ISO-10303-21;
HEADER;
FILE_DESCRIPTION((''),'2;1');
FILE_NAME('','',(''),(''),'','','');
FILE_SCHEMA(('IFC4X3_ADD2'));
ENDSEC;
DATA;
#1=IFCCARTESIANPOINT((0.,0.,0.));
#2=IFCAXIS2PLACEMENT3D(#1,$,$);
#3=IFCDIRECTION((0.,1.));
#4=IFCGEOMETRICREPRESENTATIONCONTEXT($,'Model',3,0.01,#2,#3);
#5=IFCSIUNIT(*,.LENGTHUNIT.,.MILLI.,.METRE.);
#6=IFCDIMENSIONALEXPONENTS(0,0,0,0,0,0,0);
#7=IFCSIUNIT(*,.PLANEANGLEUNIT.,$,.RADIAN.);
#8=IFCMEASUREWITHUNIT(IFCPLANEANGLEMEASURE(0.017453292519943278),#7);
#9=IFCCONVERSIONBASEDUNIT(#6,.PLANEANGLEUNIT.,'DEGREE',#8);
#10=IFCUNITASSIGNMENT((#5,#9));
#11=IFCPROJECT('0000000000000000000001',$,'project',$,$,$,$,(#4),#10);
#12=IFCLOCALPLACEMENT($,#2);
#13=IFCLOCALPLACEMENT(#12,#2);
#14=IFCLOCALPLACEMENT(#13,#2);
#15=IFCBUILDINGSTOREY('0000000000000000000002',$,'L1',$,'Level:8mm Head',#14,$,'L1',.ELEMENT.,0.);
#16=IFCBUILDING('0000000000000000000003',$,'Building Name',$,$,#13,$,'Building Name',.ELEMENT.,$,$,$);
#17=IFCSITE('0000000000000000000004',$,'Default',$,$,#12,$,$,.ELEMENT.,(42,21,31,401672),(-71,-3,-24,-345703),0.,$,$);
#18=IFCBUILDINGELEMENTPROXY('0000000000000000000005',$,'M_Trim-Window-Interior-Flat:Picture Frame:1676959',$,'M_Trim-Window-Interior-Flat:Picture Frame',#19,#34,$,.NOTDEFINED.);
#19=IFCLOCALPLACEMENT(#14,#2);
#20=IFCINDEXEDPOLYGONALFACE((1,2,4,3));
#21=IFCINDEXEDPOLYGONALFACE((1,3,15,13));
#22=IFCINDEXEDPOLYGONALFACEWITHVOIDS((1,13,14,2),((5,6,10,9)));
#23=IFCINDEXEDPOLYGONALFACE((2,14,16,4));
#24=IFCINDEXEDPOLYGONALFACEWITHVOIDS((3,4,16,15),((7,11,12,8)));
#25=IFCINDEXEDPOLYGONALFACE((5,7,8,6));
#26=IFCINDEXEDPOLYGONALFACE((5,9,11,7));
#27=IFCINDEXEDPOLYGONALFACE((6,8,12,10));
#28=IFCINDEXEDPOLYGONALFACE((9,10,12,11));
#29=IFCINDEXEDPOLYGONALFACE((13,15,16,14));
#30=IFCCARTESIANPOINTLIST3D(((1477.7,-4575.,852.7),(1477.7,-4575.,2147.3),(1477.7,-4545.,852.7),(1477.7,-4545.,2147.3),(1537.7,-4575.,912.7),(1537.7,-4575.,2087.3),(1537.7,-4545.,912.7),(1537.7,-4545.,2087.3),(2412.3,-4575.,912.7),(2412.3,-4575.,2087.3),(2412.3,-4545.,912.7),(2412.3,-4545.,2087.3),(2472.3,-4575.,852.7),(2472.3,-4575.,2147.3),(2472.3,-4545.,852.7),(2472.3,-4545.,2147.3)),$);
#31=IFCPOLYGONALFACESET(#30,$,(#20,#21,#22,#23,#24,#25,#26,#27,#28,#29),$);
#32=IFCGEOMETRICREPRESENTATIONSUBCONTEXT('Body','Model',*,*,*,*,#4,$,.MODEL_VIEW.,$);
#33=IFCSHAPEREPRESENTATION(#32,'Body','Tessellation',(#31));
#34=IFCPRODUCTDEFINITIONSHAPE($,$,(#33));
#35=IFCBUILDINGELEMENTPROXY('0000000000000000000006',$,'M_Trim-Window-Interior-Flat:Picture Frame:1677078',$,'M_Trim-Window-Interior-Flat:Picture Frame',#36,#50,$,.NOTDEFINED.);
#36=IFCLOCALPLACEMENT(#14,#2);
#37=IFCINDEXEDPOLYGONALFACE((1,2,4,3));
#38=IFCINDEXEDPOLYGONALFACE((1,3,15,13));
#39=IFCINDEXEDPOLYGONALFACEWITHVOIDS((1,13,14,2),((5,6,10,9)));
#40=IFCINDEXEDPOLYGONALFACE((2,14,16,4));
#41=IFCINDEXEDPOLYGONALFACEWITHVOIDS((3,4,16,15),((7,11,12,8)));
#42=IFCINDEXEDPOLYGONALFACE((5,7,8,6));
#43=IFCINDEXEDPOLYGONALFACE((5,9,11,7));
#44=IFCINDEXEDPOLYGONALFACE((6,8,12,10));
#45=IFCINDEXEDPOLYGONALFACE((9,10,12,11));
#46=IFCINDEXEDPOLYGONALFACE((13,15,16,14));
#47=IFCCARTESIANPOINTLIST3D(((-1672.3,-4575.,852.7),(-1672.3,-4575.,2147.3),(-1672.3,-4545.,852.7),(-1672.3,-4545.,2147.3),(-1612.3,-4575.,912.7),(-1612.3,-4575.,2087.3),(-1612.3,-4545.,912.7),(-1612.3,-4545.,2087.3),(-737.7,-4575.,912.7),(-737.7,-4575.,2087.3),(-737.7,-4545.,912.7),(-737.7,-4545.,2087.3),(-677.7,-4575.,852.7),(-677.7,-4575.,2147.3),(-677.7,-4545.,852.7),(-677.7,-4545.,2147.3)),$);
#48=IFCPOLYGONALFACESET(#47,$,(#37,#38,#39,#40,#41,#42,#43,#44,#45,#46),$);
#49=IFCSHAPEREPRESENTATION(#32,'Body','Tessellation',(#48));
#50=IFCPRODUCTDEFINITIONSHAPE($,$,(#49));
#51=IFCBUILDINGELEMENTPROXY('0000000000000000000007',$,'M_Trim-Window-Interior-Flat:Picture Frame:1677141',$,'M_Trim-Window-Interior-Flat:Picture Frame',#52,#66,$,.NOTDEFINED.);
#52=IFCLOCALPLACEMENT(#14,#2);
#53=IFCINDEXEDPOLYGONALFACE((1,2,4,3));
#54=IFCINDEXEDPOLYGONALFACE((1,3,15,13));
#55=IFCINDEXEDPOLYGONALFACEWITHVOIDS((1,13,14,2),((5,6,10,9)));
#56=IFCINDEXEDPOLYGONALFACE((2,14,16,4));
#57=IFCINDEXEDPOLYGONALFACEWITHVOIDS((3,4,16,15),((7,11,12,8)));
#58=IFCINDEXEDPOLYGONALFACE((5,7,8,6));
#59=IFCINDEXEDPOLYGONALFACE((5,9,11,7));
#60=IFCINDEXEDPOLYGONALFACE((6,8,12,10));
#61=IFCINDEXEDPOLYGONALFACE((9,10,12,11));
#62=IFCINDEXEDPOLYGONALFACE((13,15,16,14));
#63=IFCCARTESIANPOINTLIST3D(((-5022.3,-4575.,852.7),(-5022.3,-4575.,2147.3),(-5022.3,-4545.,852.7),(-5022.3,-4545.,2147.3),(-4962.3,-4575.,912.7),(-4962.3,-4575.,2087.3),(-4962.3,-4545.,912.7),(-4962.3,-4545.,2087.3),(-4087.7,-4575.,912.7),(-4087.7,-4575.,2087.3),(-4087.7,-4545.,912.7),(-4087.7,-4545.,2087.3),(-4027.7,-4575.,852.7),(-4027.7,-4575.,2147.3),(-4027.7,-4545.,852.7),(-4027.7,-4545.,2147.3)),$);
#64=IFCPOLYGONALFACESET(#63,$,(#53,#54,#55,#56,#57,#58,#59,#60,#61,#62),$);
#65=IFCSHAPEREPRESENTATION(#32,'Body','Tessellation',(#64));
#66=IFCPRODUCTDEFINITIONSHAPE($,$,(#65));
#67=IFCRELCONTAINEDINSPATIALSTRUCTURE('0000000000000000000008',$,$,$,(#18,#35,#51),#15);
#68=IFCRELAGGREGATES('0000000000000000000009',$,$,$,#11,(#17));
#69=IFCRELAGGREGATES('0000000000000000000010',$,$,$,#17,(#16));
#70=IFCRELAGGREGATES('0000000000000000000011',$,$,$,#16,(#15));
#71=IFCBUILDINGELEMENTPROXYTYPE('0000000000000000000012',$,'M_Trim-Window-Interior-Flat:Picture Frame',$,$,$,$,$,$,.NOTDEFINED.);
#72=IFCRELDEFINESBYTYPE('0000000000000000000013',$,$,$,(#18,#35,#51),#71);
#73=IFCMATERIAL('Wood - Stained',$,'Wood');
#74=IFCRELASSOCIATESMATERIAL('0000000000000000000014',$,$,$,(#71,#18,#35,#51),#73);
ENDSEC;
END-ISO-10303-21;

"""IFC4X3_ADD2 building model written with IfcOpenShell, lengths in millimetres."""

from ifc_helpers import new_model, entity, si_unit, converted_unit, direction, frame, origin, place, context, subcontext, project, spatial, polyline, outline, extrude, source, transform, mapped, material, type_object, type_shapes, element, save


model = new_model("IFC4X3_ADD2")

# Units and contexts
model_context = context("Model", 3, precision=0.01, world=origin(), true_north=direction((0.0, 1.0)))
body_context = subcontext(model_context, "Body", "Model", "MODEL_VIEW")
ifc_project = project(units=[si_unit("LENGTHUNIT", "METRE", prefix="MILLI"), converted_unit("PLANEANGLEUNIT", "DEGREE", entity("IfcPlaneAngleMeasure", 0.017453292519943278), si_unit("PLANEANGLEUNIT", "RADIAN"), dimensions=[0, 0, 0, 0, 0, 0, 0])], contexts=[model_context])

# Site, building, storey
site_placement = place(None, origin())
site = spatial("IfcSite", under=ifc_project, at=site_placement, Name="Default", CompositionType="ELEMENT", RefLatitude=(42, 21, 31, 401672), RefLongitude=(-71, -3, -24, -345703), RefElevation=0.0)
building_placement = place(site_placement, origin())
building = spatial("IfcBuilding", under=site, at=building_placement, Name="Building Name", LongName="Building Name", CompositionType="ELEMENT")
storey_placement = place(building_placement, origin())
storey = spatial("IfcBuildingStorey", under=building, at=storey_placement, Name="L1", ObjectType="Level:8mm Head", LongName="L1", CompositionType="ELEMENT", Elevation=0.0)

# Building element proxies
ifc_material_1 = material(Name="Wood - Stained", Category="Wood")
building_element_proxy_type_1 = type_object("IfcBuildingElementProxyType", Name="M_Trim-Window-Interior-Flat:Picture Frame", PredefinedType="NOTDEFINED", material=ifc_material_1)
shared_shape_1 = source(origin(), body_context, "Body", "SweptSolid", [
    extrude(outline(polyline([(-497.3, -647.3), (497.3, -647.3), (497.3, 647.3), (-497.3, 647.3), (-497.3, -647.3)]), holes=[polyline([(-437.3, -587.3), (-437.3, 587.3), (437.3, 587.3), (437.3, -587.3), (-437.3, -587.3)])]), frame((0.0, -600.0, 0.0), z_axis=(0.0, 0.0, 1.0), x_axis=(-1.0, 0.0, 0.0)), (0.0, 0.0, 1.0), 30.0),
])
type_shapes(building_element_proxy_type_1, [shared_shape_1])
for number, where, z_axis, x_axis, name in (
    (1, (1975.0, -4575.0, 2100.0), (0.0, 1.0, 0.0), (-1.0, 0.0, 0.0), "M_Trim-Window-Interior-Flat:Picture Frame:1676959"),
    (2, (-1175.0, -4575.0, 2100.0), (0.0, 1.0, 0.0), (-1.0, 0.0, 0.0), "M_Trim-Window-Interior-Flat:Picture Frame:1677078"),
    (3, (-4525.0, -4575.0, 2100.0), (0.0, 1.0, 0.0), (-1.0, 0.0, 0.0), "M_Trim-Window-Interior-Flat:Picture Frame:1677141"),
):
    element("IfcBuildingElementProxy", number, at=place(storey_placement, frame(where, z_axis=z_axis, x_axis=x_axis)), inside=storey, type_object=building_element_proxy_type_1, material=ifc_material_1, Name=name, ObjectType="M_Trim-Window-Interior-Flat:Picture Frame", PredefinedType="NOTDEFINED", context=body_context, shape_type="MappedRepresentation", body=[
        mapped(shared_shape_1, transform((0.0, 0.0, 0.0), scale=1.0)),
    ])

save(model, "model.ifc")
